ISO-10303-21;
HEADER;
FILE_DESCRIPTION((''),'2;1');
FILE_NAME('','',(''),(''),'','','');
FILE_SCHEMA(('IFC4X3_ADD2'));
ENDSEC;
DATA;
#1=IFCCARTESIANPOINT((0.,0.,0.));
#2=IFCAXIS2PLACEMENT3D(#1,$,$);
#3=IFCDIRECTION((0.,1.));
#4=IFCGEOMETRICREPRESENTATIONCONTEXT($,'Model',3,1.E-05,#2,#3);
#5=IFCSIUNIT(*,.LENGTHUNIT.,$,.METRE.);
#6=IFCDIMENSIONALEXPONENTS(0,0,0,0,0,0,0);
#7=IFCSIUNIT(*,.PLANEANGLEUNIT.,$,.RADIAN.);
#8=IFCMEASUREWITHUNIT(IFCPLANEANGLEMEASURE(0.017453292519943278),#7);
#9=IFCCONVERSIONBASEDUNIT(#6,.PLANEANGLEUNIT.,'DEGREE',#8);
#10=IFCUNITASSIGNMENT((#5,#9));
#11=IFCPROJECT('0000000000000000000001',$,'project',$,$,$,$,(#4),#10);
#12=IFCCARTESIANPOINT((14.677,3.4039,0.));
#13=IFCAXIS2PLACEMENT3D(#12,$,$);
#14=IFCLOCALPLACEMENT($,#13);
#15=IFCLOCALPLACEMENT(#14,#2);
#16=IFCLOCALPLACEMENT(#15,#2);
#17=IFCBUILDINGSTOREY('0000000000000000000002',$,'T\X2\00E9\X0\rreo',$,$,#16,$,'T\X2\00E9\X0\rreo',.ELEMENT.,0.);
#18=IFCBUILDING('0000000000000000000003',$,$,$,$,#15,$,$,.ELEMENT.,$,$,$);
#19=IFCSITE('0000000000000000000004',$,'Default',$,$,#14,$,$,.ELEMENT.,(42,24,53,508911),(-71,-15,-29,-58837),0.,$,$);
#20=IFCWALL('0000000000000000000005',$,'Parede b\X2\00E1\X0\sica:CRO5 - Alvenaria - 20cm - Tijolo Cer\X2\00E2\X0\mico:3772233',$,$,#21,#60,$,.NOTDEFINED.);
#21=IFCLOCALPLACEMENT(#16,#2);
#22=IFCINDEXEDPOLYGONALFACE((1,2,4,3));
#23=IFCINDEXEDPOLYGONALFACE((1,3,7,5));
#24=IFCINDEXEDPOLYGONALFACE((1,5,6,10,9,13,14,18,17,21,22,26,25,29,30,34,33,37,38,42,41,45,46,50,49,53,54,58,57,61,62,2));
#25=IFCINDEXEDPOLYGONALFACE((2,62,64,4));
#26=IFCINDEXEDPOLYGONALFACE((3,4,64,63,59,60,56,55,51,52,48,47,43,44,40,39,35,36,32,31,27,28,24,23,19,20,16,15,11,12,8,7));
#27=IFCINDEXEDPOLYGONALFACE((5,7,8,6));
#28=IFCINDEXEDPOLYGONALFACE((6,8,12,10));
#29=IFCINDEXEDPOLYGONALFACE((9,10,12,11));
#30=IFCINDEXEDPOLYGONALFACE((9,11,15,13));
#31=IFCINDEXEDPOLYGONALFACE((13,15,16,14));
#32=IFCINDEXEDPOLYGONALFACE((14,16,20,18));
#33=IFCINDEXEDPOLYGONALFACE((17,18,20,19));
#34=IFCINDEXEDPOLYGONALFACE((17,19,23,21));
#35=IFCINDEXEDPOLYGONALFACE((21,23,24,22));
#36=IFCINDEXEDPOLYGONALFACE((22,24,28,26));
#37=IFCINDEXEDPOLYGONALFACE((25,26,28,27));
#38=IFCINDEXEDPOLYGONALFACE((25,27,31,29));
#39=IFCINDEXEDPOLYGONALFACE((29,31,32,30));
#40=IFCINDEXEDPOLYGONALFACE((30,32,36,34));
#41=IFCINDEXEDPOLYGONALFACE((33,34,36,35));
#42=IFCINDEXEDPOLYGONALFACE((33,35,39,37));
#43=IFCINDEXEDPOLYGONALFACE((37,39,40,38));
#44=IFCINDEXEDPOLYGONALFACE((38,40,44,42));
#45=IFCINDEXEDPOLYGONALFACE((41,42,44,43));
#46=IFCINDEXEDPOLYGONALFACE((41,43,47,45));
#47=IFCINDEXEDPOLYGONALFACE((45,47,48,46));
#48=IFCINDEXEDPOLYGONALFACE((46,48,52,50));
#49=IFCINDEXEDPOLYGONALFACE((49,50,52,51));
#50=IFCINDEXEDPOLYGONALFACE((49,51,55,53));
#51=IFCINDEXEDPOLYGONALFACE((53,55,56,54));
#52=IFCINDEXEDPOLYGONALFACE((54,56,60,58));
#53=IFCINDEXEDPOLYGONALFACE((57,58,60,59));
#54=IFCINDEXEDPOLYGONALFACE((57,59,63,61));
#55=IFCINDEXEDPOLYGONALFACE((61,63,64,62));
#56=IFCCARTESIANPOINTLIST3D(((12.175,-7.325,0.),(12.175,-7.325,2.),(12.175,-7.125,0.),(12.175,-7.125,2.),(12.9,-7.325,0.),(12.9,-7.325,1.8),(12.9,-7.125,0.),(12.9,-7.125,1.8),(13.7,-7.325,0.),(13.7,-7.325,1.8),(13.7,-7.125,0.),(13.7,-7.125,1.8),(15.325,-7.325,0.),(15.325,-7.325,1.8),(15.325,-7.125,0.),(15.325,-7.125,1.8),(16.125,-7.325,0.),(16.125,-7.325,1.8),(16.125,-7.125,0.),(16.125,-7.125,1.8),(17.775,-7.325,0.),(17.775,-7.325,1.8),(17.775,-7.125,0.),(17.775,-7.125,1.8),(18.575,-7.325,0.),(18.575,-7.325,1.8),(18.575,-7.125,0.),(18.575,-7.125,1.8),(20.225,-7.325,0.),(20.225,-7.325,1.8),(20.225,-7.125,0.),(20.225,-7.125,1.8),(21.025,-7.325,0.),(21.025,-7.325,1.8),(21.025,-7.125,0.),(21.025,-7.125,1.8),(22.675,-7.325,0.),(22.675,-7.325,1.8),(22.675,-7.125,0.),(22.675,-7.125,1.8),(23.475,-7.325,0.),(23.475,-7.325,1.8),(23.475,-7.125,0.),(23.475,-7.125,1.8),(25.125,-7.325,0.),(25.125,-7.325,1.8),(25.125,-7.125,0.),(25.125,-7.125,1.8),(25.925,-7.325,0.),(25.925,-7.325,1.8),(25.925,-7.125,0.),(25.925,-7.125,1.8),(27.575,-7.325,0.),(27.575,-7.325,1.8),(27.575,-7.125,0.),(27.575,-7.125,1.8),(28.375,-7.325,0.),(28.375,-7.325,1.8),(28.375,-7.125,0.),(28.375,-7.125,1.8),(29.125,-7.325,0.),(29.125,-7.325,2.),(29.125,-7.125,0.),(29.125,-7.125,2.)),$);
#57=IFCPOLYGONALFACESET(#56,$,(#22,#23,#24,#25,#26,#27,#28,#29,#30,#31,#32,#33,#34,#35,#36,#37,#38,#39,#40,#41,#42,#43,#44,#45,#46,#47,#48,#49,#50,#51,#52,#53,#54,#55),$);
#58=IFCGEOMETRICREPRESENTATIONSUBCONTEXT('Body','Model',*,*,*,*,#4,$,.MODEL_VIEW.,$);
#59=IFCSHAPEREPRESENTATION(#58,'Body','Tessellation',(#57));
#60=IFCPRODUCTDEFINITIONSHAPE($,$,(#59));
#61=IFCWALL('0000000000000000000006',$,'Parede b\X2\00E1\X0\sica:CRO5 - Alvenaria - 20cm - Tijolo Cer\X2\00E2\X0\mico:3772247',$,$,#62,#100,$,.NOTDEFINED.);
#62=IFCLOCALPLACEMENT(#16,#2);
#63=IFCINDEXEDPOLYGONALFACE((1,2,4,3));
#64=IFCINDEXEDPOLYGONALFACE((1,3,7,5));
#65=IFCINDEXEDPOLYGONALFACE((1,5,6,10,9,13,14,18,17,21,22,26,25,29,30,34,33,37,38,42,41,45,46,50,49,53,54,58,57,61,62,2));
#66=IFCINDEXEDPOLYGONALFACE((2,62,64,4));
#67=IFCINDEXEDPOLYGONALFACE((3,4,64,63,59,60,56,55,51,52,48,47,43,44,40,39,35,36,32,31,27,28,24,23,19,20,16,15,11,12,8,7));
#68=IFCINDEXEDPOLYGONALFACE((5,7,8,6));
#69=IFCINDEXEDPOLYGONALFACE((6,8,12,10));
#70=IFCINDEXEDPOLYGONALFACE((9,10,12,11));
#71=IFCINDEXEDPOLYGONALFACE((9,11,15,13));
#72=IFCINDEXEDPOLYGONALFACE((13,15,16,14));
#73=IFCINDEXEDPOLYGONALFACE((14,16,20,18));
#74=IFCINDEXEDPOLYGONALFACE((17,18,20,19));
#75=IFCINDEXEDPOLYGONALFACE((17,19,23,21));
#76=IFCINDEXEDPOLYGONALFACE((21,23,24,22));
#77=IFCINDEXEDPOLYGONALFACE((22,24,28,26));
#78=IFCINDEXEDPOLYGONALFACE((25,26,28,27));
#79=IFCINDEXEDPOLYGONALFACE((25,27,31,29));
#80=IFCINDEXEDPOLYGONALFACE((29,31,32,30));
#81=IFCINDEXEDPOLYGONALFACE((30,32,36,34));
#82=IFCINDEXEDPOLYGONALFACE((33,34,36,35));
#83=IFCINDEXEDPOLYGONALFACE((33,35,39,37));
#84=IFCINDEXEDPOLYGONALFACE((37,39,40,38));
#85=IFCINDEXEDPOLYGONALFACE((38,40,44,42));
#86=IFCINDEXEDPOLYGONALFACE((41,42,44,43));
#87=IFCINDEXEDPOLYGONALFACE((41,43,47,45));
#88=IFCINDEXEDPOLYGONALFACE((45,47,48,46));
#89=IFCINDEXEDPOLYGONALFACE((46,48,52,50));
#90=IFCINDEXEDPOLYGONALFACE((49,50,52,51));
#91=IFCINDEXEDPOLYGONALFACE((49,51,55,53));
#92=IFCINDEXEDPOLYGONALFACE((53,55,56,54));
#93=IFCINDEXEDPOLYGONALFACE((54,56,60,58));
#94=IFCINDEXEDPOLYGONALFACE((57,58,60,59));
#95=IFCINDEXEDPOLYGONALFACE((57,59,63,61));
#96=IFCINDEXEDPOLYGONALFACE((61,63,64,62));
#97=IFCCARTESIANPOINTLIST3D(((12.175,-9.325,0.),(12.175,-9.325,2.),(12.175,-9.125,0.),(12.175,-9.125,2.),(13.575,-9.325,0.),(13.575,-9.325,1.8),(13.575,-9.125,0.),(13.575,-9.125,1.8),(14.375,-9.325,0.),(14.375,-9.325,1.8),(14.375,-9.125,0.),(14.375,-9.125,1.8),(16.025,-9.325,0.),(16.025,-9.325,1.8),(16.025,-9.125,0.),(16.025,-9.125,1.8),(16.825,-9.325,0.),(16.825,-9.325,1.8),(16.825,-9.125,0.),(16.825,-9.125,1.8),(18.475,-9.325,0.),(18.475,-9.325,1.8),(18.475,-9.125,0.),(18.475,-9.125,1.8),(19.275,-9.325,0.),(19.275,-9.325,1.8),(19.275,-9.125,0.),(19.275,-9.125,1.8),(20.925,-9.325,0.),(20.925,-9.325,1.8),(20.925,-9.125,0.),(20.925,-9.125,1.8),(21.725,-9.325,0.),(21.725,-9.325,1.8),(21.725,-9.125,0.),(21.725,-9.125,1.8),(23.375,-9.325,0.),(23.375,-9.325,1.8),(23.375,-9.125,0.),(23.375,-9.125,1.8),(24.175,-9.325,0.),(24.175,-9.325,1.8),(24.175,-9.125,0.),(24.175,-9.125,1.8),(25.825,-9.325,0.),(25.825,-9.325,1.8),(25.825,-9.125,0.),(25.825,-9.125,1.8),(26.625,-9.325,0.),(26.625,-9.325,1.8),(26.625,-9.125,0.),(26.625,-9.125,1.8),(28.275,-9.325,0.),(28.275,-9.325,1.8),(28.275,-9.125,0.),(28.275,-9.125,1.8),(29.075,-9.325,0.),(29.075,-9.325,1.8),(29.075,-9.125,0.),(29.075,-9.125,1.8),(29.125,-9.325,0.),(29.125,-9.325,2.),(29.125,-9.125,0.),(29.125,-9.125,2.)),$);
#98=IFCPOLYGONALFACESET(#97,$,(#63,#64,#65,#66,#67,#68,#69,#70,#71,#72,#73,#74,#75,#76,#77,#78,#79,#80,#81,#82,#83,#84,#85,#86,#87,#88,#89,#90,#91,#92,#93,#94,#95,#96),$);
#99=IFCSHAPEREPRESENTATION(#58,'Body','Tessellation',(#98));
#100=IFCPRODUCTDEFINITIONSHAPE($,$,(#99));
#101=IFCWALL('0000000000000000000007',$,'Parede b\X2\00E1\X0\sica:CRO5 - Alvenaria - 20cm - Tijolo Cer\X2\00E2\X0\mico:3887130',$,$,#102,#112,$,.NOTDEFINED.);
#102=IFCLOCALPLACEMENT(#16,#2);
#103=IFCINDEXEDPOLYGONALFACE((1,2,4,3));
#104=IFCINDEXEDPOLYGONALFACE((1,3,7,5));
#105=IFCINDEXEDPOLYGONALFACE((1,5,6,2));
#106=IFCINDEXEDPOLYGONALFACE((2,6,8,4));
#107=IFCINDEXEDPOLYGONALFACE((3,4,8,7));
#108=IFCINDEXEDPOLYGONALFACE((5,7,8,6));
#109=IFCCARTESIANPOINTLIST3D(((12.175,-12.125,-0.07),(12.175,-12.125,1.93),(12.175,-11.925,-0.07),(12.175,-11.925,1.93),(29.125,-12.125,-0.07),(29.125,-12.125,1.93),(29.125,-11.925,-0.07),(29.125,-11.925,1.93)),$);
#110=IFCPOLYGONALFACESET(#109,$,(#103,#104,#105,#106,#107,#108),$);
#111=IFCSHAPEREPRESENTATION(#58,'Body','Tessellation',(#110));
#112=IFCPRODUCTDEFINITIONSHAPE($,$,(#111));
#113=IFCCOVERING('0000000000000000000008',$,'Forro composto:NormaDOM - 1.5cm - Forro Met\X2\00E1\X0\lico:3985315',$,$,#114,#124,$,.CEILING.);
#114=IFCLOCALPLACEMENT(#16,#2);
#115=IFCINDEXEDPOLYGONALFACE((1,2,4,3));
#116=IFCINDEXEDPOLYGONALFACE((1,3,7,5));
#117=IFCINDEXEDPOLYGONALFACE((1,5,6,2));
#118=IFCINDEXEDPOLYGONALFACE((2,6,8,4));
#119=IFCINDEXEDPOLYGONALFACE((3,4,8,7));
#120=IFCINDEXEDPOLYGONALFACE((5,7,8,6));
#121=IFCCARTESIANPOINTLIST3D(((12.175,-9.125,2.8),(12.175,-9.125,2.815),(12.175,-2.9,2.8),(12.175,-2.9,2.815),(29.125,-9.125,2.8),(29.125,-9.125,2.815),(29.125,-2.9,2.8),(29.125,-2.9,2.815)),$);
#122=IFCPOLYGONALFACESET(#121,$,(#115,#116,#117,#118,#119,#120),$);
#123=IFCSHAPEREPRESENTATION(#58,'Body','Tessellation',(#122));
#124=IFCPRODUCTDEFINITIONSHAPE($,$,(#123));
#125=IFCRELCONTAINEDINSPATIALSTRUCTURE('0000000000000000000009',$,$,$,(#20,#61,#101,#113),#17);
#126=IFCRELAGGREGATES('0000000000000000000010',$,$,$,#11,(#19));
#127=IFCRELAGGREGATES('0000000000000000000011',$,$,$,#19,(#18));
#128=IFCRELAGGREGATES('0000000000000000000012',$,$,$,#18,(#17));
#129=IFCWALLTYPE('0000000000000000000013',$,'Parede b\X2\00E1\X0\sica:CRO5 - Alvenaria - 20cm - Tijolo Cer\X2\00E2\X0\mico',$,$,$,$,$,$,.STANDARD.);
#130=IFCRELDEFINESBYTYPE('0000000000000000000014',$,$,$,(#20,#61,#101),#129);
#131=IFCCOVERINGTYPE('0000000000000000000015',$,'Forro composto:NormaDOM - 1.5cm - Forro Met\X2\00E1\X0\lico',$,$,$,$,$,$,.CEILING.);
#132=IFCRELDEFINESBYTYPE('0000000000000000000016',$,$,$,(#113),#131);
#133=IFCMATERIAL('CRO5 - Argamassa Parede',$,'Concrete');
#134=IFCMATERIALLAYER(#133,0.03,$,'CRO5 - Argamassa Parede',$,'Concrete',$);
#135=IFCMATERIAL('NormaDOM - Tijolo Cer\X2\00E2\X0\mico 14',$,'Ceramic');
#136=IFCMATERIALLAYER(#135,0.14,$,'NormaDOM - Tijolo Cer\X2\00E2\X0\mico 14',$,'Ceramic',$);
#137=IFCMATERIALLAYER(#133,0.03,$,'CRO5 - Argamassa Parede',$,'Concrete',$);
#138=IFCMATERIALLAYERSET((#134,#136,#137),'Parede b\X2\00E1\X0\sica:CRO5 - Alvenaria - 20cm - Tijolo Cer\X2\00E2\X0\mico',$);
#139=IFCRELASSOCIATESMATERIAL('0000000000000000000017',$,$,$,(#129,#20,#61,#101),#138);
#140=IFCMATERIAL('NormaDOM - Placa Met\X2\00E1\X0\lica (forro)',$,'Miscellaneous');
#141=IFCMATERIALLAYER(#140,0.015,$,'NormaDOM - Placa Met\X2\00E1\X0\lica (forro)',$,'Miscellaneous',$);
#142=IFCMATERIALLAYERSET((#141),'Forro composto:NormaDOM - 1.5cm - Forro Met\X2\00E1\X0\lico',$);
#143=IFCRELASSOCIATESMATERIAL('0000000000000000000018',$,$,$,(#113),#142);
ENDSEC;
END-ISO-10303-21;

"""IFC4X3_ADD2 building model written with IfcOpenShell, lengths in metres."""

from ifc_helpers import new_model, entity, si_unit, converted_unit, direction, frame, frame_2d, origin, origin_2d_with_axis, place, context, subcontext, project, spatial, rectangle, extrude, material, layer, layer_set, layer_usage, type_object, element, save


model = new_model("IFC4X3_ADD2")

# Units and contexts
model_context = context("Model", 3, precision=1e-05, world=origin(), true_north=direction((0.0, 1.0)))
body_context = subcontext(model_context, "Body", "Model", "MODEL_VIEW")
ifc_project = project(units=[si_unit("LENGTHUNIT", "METRE"), converted_unit("PLANEANGLEUNIT", "DEGREE", entity("IfcPlaneAngleMeasure", 0.017453292519943278), si_unit("PLANEANGLEUNIT", "RADIAN"), dimensions=[0, 0, 0, 0, 0, 0, 0])], contexts=[model_context])

# Site, building, storey
site_placement = place(None, frame((14.677, 3.4039, 0.0)))
site = spatial("IfcSite", under=ifc_project, at=site_placement, Name="Default", CompositionType="ELEMENT", RefLatitude=(42, 24, 53, 508911), RefLongitude=(-71, -15, -29, -58837), RefElevation=0.0)
building_placement = place(site_placement, origin())
building = spatial("IfcBuilding", under=site, at=building_placement, CompositionType="ELEMENT")
storey_placement = place(building_placement, origin())
storey = spatial("IfcBuildingStorey", under=building, at=storey_placement, Name="Térreo", LongName="Térreo", CompositionType="ELEMENT", Elevation=0.0)

# Walls, openings
ifc_material_1 = material(Name="CRO5 - Argamassa Parede", Category="Concrete")
ifc_layer_1 = layer(ifc_material_1, 0.03, Name="CRO5 - Argamassa Parede", Category="Concrete")
ifc_material_2 = material(Name="NormaDOM - Tijolo Cerâmico 14", Category="Ceramic")
ifc_layer_2 = layer(ifc_material_2, 0.14, Name="NormaDOM - Tijolo Cerâmico 14", Category="Ceramic")
ifc_layer_3 = layer(ifc_material_1, 0.03, Name="CRO5 - Argamassa Parede", Category="Concrete")
ifc_layer_set_1 = layer_set([ifc_layer_1, ifc_layer_2, ifc_layer_3], Name="Parede básica:CRO5 - Alvenaria - 20cm - Tijolo Cerâmico")
wall_type = type_object("IfcWallType", Name="Parede básica:CRO5 - Alvenaria - 20cm - Tijolo Cerâmico", PredefinedType="STANDARD", material=ifc_layer_set_1)
wall_1_placement = place(storey_placement, frame((12.175, -7.225, 0.0)))
wall_1 = element("IfcWall", 1, at=wall_1_placement, inside=storey, type_object=wall_type, material=ifc_layer_set_1, Name="Parede básica:CRO5 - Alvenaria - 20cm - Tijolo Cerâmico:3772233", PredefinedType="NOTDEFINED", context=body_context, shape_type="SweptSolid", body=[
    extrude(rectangle(XDim=16.95, YDim=0.2, at=frame_2d((8.475, 0.0), x_axis=(1.0, 0.0))), origin(), (0.0, 0.0, 1.0), 2.0),
])
opening_1_placement = place(wall_1_placement, frame((0.725, -0.1, 0.0)))
element("IfcOpeningElement", 2, at=opening_1_placement, cuts=wall_1, PredefinedType="OPENING", context=body_context, shape_type="SweptSolid", body=[
    extrude(rectangle(XDim=1.8, YDim=0.8, at=frame_2d((0.9, 0.4), x_axis=(1.0, 0.0))), frame((0.0, 0.0, 0.0), z_axis=(0.0, 1.0, 0.0), x_axis=(0.0, 0.0, 1.0)), (0.0, 0.0, 1.0), 0.2),
])
opening_2_placement = place(wall_1_placement, frame((15.4, -0.1, 0.0)))
element("IfcOpeningElement", 3, at=opening_2_placement, cuts=wall_1, PredefinedType="OPENING", context=body_context, shape_type="SweptSolid", body=[
    extrude(rectangle(XDim=1.8, YDim=0.8, at=frame_2d((0.9, 0.4), x_axis=(1.0, 0.0))), frame((0.0, 0.0, 0.0), z_axis=(0.0, 1.0, 0.0), x_axis=(0.0, 0.0, 1.0)), (0.0, 0.0, 1.0), 0.2),
])
opening_3_placement = place(wall_1_placement, frame((12.95, -0.1, 0.0)))
element("IfcOpeningElement", 4, at=opening_3_placement, cuts=wall_1, PredefinedType="OPENING", context=body_context, shape_type="SweptSolid", body=[
    extrude(rectangle(XDim=1.8, YDim=0.8, at=frame_2d((0.9, 0.4), x_axis=(1.0, 0.0))), frame((0.0, 0.0, 0.0), z_axis=(0.0, 1.0, 0.0), x_axis=(0.0, 0.0, 1.0)), (0.0, 0.0, 1.0), 0.2),
])
opening_4_placement = place(wall_1_placement, frame((10.5, -0.1, 0.0)))
element("IfcOpeningElement", 5, at=opening_4_placement, cuts=wall_1, PredefinedType="OPENING", context=body_context, shape_type="SweptSolid", body=[
    extrude(rectangle(XDim=1.8, YDim=0.8, at=frame_2d((0.9, 0.4), x_axis=(1.0, 0.0))), frame((0.0, 0.0, 0.0), z_axis=(0.0, 1.0, 0.0), x_axis=(0.0, 0.0, 1.0)), (0.0, 0.0, 1.0), 0.2),
])
opening_5_placement = place(wall_1_placement, frame((8.05, -0.1, 0.0)))
element("IfcOpeningElement", 6, at=opening_5_placement, cuts=wall_1, PredefinedType="OPENING", context=body_context, shape_type="SweptSolid", body=[
    extrude(rectangle(XDim=1.8, YDim=0.8, at=frame_2d((0.9, 0.4), x_axis=(1.0, 0.0))), frame((0.0, 0.0, 0.0), z_axis=(0.0, 1.0, 0.0), x_axis=(0.0, 0.0, 1.0)), (0.0, 0.0, 1.0), 0.2),
])
opening_6_placement = place(wall_1_placement, frame((5.6, -0.1, 0.0)))
element("IfcOpeningElement", 7, at=opening_6_placement, cuts=wall_1, PredefinedType="OPENING", context=body_context, shape_type="SweptSolid", body=[
    extrude(rectangle(XDim=1.8, YDim=0.8, at=frame_2d((0.9, 0.4), x_axis=(1.0, 0.0))), frame((0.0, 0.0, 0.0), z_axis=(0.0, 1.0, 0.0), x_axis=(0.0, 0.0, 1.0)), (0.0, 0.0, 1.0), 0.2),
])
opening_7_placement = place(wall_1_placement, frame((3.15, -0.1, 0.0)))
element("IfcOpeningElement", 8, at=opening_7_placement, cuts=wall_1, PredefinedType="OPENING", context=body_context, shape_type="SweptSolid", body=[
    extrude(rectangle(XDim=1.8, YDim=0.8, at=frame_2d((0.9, 0.4), x_axis=(1.0, 0.0))), frame((0.0, 0.0, 0.0), z_axis=(0.0, 1.0, 0.0), x_axis=(0.0, 0.0, 1.0)), (0.0, 0.0, 1.0), 0.2),
])
wall_2_placement = place(storey_placement, frame((12.175, -9.225, 0.0)))
wall_2 = element("IfcWall", 9, at=wall_2_placement, inside=storey, type_object=wall_type, material=ifc_layer_set_1, Name="Parede básica:CRO5 - Alvenaria - 20cm - Tijolo Cerâmico:3772247", PredefinedType="NOTDEFINED", context=body_context, shape_type="SweptSolid", body=[
    extrude(rectangle(XDim=16.95, YDim=0.2, at=frame_2d((8.475, 0.0), x_axis=(1.0, 0.0))), origin(), (0.0, 0.0, 1.0), 2.0),
])
opening_8_placement = place(wall_2_placement, frame((1.4, -0.1, 0.0)))
element("IfcOpeningElement", 10, at=opening_8_placement, cuts=wall_2, PredefinedType="OPENING", context=body_context, shape_type="SweptSolid", body=[
    extrude(rectangle(XDim=1.8, YDim=0.8, at=frame_2d((0.9, 0.4), x_axis=(1.0, 0.0))), frame((0.0, 0.0, 0.0), z_axis=(0.0, 1.0, 0.0), x_axis=(0.0, 0.0, 1.0)), (0.0, 0.0, 1.0), 0.2),
])
opening_9_placement = place(wall_2_placement, frame((3.85, -0.1, 0.0)))
element("IfcOpeningElement", 11, at=opening_9_placement, cuts=wall_2, PredefinedType="OPENING", context=body_context, shape_type="SweptSolid", body=[
    extrude(rectangle(XDim=1.8, YDim=0.8, at=frame_2d((0.9, 0.4), x_axis=(1.0, 0.0))), frame((0.0, 0.0, 0.0), z_axis=(0.0, 1.0, 0.0), x_axis=(0.0, 0.0, 1.0)), (0.0, 0.0, 1.0), 0.2),
])
opening_10_placement = place(wall_2_placement, frame((6.3, -0.1, 0.0)))
element("IfcOpeningElement", 12, at=opening_10_placement, cuts=wall_2, PredefinedType="OPENING", context=body_context, shape_type="SweptSolid", body=[
    extrude(rectangle(XDim=1.8, YDim=0.8, at=frame_2d((0.9, 0.4), x_axis=(1.0, 0.0))), frame((0.0, 0.0, 0.0), z_axis=(0.0, 1.0, 0.0), x_axis=(0.0, 0.0, 1.0)), (0.0, 0.0, 1.0), 0.2),
])
opening_11_placement = place(wall_2_placement, frame((8.75, -0.1, 0.0)))
element("IfcOpeningElement", 13, at=opening_11_placement, cuts=wall_2, PredefinedType="OPENING", context=body_context, shape_type="SweptSolid", body=[
    extrude(rectangle(XDim=1.8, YDim=0.8, at=frame_2d((0.9, 0.4), x_axis=(1.0, 0.0))), frame((0.0, 0.0, 0.0), z_axis=(0.0, 1.0, 0.0), x_axis=(0.0, 0.0, 1.0)), (0.0, 0.0, 1.0), 0.2),
])
opening_12_placement = place(wall_2_placement, frame((11.2, -0.1, 0.0)))
element("IfcOpeningElement", 14, at=opening_12_placement, cuts=wall_2, PredefinedType="OPENING", context=body_context, shape_type="SweptSolid", body=[
    extrude(rectangle(XDim=1.8, YDim=0.8, at=frame_2d((0.9, 0.4), x_axis=(1.0, 0.0))), frame((0.0, 0.0, 0.0), z_axis=(0.0, 1.0, 0.0), x_axis=(0.0, 0.0, 1.0)), (0.0, 0.0, 1.0), 0.2),
])
opening_13_placement = place(wall_2_placement, frame((13.65, -0.1, 0.0)))
element("IfcOpeningElement", 15, at=opening_13_placement, cuts=wall_2, PredefinedType="OPENING", context=body_context, shape_type="SweptSolid", body=[
    extrude(rectangle(XDim=1.8, YDim=0.8, at=frame_2d((0.9, 0.4), x_axis=(1.0, 0.0))), frame((0.0, 0.0, 0.0), z_axis=(0.0, 1.0, 0.0), x_axis=(0.0, 0.0, 1.0)), (0.0, 0.0, 1.0), 0.2),
])
opening_14_placement = place(wall_2_placement, frame((16.1, -0.1, 0.0)))
element("IfcOpeningElement", 16, at=opening_14_placement, cuts=wall_2, PredefinedType="OPENING", context=body_context, shape_type="SweptSolid", body=[
    extrude(rectangle(XDim=1.8, YDim=0.8, at=frame_2d((0.9, 0.4), x_axis=(1.0, 0.0))), frame((0.0, 0.0, 0.0), z_axis=(0.0, 1.0, 0.0), x_axis=(0.0, 0.0, 1.0)), (0.0, 0.0, 1.0), 0.2),
])

# Wall
wall_3_placement = place(storey_placement, frame((12.175, -12.025, -0.07)))
element("IfcWall", 17, at=wall_3_placement, inside=storey, type_object=wall_type, material=ifc_layer_set_1, Name="Parede básica:CRO5 - Alvenaria - 20cm - Tijolo Cerâmico:3887130", PredefinedType="NOTDEFINED", context=body_context, shape_type="SweptSolid", body=[
    extrude(rectangle(XDim=16.95, YDim=0.2, at=frame_2d((8.475, 0.0), x_axis=(-1.0, 0.0))), origin(), (0.0, 0.0, 1.0), 2.0),
])

# Covering
ifc_material_3 = material(Name="NormaDOM - Placa Metálica (forro)", Category="Miscellaneous")
ifc_layer_4 = layer(ifc_material_3, 0.015, Name="NormaDOM - Placa Metálica (forro)", Category="Miscellaneous")
ifc_layer_set_2 = layer_set([ifc_layer_4], Name="Forro composto:NormaDOM - 1.5cm - Forro Metálico")
ifc_layer_usage_1 = layer_usage(ifc_layer_set_2, "AXIS3", "NEGATIVE", 0.015)
covering_type = type_object("IfcCoveringType", Name="Forro composto:NormaDOM - 1.5cm - Forro Metálico", PredefinedType="CEILING")
covering_placement = place(storey_placement, frame((12.175, -9.125, 2.8)))
element("IfcCovering", 18, at=covering_placement, inside=storey, type_object=covering_type, material=ifc_layer_usage_1, Name="Forro composto:NormaDOM - 1.5cm - Forro Metálico:3985315", PredefinedType="CEILING", context=body_context, shape_type="SweptSolid", body=[
    extrude(rectangle(XDim=16.95, YDim=6.225, at=origin_2d_with_axis()), frame((8.475, 3.1125, 0.0), z_axis=(0.0, 0.0, 1.0), x_axis=(-1.0, 0.0, 0.0)), (0.0, 0.0, 1.0), 0.015),
])

save(model, "model.ifc")
